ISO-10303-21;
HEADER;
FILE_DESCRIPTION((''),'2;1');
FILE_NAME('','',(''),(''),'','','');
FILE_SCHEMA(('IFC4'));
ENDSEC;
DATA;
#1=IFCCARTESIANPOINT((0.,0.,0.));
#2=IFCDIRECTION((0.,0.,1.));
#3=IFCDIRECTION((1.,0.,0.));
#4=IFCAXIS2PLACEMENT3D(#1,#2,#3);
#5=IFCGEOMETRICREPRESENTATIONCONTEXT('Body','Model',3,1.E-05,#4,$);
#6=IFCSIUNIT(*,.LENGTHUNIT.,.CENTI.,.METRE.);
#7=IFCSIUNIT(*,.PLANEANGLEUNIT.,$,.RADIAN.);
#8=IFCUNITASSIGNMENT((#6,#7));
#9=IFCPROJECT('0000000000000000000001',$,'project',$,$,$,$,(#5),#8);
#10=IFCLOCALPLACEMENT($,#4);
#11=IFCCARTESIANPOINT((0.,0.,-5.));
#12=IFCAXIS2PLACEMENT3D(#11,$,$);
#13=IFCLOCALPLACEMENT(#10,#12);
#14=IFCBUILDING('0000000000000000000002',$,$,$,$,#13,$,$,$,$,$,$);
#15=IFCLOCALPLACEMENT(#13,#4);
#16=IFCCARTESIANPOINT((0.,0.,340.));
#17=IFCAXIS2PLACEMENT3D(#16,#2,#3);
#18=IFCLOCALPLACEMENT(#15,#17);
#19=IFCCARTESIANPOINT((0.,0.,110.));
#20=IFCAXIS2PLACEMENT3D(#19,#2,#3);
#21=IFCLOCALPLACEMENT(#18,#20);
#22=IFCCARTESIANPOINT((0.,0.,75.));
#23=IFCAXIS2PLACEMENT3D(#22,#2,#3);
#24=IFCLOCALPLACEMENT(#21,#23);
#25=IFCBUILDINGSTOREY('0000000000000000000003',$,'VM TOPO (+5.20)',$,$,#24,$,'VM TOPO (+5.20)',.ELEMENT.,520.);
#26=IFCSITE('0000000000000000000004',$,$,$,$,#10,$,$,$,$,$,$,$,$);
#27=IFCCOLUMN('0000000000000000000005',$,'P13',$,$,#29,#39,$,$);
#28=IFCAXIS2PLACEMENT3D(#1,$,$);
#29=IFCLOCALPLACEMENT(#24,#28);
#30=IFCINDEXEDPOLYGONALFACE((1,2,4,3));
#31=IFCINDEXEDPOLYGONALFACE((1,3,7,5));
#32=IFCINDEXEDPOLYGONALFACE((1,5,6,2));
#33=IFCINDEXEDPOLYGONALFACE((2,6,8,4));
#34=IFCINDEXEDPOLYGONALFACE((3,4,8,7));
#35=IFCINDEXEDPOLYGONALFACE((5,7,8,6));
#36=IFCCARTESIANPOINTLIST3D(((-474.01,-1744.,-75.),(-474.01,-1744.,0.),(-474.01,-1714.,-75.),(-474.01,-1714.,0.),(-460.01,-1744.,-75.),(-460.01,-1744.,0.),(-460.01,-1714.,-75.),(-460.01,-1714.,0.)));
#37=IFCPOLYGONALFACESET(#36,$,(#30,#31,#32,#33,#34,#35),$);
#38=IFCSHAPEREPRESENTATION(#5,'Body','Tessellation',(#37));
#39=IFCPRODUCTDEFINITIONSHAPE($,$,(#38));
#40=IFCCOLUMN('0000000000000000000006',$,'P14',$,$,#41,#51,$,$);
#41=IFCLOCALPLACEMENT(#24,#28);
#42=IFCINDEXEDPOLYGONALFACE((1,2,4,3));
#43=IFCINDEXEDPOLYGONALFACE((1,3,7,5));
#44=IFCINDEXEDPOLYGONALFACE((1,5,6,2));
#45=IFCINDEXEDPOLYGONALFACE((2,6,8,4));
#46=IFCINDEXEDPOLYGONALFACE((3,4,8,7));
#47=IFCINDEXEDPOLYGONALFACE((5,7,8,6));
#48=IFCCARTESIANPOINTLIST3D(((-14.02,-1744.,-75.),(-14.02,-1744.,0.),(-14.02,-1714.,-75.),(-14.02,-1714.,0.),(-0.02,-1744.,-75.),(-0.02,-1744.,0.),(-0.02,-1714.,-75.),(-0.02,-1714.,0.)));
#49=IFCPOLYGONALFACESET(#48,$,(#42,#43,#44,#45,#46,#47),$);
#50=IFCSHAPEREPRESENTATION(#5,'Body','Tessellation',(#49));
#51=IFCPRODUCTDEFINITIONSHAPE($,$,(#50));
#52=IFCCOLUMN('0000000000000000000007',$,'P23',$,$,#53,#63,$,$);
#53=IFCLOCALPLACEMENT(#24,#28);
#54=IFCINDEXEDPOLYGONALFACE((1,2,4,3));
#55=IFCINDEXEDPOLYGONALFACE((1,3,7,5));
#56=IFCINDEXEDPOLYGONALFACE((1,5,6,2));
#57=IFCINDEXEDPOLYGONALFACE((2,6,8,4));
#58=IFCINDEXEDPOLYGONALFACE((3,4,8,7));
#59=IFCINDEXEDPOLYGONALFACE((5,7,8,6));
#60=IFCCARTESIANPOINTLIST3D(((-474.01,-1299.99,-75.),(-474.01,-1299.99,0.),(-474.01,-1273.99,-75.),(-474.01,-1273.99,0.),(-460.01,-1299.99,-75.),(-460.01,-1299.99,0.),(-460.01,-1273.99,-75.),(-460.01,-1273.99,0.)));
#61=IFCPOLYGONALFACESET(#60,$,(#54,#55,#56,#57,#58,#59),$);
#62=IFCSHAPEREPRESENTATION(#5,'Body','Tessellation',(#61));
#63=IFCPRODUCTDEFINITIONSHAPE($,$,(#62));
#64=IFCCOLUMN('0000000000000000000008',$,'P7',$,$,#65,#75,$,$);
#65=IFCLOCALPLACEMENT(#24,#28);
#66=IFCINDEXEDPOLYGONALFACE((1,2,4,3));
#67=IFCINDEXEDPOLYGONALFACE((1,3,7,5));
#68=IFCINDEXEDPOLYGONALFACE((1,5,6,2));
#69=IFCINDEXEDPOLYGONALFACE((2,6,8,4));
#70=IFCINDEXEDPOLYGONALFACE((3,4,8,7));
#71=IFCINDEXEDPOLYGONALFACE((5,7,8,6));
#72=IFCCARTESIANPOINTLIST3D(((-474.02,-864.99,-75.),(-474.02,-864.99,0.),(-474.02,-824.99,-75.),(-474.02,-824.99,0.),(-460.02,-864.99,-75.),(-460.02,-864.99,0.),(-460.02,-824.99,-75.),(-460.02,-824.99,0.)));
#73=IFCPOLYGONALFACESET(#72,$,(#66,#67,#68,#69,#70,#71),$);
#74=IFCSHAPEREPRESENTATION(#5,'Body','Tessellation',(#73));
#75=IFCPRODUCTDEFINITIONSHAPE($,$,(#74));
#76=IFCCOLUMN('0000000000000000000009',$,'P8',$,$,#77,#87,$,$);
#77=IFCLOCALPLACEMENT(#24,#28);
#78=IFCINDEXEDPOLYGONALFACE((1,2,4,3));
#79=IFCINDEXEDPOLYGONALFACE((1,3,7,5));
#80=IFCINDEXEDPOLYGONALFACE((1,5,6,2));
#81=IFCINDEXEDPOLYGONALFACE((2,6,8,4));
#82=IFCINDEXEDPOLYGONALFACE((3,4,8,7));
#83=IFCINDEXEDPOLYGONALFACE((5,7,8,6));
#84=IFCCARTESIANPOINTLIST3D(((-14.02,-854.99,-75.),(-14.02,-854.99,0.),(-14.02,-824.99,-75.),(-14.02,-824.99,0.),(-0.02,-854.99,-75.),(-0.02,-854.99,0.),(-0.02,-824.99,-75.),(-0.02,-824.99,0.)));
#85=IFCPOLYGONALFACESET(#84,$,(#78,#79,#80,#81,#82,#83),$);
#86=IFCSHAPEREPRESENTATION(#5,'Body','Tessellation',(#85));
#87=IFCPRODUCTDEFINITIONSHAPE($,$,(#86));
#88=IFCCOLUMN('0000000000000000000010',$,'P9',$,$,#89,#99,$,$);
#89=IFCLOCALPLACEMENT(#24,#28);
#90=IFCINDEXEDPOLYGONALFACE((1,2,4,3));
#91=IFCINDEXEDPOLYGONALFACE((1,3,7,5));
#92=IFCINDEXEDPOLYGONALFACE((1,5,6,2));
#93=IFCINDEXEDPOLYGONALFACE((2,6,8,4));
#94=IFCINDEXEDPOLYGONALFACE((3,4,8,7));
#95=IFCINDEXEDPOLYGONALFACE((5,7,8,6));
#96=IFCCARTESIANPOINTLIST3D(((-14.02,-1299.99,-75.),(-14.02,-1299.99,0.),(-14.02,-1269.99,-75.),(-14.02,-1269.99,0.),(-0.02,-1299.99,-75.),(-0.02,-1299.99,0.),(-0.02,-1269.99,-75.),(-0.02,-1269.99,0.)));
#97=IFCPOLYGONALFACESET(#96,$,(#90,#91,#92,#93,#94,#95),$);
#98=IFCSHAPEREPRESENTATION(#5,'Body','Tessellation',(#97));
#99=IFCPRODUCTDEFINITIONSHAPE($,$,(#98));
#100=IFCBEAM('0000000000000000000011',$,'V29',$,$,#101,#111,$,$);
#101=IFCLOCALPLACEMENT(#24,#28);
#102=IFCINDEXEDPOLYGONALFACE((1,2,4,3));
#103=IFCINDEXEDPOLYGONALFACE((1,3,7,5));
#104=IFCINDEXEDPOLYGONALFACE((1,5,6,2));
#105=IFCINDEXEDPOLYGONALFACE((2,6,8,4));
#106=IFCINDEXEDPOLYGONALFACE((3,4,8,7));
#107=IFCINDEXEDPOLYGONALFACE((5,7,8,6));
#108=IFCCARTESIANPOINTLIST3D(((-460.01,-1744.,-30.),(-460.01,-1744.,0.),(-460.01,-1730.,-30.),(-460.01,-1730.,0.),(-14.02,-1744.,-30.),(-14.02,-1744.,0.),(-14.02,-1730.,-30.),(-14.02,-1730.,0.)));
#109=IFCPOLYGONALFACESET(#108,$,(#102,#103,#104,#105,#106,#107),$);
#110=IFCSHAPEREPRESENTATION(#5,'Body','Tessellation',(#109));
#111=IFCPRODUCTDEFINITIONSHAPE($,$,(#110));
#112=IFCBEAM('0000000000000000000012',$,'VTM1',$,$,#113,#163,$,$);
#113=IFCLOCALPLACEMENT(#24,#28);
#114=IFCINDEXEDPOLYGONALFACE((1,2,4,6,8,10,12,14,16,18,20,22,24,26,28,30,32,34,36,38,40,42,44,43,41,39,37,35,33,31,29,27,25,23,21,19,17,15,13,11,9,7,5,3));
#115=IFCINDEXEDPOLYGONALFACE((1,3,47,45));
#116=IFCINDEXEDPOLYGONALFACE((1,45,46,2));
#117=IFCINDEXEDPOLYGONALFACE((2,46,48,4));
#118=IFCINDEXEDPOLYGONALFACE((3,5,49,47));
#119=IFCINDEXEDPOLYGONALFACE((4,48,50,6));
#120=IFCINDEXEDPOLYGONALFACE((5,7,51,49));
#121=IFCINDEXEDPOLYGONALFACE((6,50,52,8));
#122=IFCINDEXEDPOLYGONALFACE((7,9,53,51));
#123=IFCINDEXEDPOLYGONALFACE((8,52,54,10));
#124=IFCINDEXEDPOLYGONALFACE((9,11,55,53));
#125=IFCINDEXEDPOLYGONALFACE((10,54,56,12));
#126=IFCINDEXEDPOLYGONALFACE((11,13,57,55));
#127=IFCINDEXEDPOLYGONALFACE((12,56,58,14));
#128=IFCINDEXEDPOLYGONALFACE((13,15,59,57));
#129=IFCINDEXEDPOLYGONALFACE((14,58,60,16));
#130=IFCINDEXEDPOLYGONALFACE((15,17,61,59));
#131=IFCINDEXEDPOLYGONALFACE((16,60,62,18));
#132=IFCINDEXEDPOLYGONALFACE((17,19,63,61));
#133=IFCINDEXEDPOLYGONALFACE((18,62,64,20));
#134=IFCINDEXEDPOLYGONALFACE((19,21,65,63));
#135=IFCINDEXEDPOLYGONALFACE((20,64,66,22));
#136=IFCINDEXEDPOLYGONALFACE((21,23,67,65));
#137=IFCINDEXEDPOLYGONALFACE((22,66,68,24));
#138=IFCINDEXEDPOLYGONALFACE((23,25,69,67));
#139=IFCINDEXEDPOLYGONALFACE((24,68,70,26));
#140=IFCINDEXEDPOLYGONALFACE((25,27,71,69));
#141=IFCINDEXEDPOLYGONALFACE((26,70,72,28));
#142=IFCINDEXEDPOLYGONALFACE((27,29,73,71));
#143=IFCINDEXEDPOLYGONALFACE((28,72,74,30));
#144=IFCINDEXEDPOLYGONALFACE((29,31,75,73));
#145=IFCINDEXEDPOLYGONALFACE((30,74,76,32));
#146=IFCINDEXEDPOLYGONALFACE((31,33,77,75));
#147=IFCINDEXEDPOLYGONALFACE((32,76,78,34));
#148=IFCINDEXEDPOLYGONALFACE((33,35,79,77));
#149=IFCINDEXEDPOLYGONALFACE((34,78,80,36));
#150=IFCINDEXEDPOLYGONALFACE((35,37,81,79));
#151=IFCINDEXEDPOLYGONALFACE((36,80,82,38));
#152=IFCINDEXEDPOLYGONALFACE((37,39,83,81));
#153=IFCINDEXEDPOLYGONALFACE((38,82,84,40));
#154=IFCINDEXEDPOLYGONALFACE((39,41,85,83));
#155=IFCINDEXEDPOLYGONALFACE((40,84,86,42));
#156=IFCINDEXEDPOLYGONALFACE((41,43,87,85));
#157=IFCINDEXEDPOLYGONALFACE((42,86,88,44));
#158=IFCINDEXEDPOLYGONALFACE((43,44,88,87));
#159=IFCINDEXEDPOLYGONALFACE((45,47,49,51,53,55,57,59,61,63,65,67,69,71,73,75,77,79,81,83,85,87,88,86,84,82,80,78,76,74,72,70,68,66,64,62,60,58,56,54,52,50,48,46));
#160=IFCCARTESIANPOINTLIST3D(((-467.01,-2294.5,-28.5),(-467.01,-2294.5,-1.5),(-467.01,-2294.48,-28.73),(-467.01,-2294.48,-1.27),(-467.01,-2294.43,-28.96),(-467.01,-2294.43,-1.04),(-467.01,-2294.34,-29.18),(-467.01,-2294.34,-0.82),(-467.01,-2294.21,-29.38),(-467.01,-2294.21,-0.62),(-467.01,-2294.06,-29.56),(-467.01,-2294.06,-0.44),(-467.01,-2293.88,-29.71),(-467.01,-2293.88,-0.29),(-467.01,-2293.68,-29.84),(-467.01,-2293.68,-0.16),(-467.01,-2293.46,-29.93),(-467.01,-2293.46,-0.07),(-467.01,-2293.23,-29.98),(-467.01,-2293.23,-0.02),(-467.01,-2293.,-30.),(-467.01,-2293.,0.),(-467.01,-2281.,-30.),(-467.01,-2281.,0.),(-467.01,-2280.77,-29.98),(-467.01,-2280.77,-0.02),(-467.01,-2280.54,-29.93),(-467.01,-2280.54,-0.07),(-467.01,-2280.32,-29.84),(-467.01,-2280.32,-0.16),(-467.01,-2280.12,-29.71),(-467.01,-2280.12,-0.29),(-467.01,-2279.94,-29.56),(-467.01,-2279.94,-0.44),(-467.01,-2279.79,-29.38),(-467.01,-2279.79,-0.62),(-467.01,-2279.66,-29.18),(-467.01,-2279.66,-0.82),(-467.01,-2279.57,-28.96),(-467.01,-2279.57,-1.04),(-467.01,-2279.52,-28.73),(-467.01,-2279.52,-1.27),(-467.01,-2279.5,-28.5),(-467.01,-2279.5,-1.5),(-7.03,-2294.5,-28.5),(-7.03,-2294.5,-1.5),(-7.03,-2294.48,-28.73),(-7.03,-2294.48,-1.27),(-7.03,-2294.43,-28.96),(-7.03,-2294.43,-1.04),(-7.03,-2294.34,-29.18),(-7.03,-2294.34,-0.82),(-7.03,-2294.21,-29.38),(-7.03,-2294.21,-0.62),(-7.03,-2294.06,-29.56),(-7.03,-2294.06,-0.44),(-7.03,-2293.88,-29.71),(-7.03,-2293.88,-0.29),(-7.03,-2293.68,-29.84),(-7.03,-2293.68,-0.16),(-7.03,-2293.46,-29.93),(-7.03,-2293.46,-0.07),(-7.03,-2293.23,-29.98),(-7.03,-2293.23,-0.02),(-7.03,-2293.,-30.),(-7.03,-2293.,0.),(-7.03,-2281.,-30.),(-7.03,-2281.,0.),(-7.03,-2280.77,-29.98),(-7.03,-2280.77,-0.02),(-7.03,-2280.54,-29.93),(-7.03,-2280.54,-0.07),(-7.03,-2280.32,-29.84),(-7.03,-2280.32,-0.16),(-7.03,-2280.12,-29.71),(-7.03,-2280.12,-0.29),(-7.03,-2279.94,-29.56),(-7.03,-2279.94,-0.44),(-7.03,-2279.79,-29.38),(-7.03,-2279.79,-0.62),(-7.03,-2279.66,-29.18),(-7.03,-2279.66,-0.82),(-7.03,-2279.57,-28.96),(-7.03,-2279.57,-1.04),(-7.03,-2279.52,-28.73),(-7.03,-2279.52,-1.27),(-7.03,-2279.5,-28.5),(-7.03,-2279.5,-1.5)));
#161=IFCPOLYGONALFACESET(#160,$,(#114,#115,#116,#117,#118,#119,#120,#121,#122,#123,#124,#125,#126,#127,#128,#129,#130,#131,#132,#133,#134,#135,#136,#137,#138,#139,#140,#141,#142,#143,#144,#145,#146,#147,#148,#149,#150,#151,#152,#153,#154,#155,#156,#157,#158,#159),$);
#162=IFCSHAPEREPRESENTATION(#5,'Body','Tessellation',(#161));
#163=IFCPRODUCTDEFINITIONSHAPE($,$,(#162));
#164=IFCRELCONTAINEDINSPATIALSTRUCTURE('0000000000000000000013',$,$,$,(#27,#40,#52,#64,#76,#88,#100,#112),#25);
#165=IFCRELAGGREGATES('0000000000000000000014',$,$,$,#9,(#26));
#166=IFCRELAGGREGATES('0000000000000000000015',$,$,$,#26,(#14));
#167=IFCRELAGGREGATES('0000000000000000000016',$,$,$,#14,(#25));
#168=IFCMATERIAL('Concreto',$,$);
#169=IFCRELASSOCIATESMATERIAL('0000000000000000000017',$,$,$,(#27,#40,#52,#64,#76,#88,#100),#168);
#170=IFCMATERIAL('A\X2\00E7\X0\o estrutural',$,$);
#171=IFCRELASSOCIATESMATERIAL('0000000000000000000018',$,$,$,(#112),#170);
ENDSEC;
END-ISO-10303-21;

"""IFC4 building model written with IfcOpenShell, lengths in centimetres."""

from ifc_helpers import new_model, si_unit, frame, origin_with_axes, origin_2d_with_axis, place, context, project, spatial, polyline, rectangle, outline, extrude, material, element, save


model = new_model("IFC4")

# Units and contexts
model_context = context("Model", 3, precision=1e-05, world=origin_with_axes(), identifier="Body")
ifc_project = project(units=[si_unit("LENGTHUNIT", "METRE", prefix="CENTI"), si_unit("PLANEANGLEUNIT", "RADIAN")], contexts=[model_context])

# Site, building, storey
site_placement = place(None, origin_with_axes())
site = spatial("IfcSite", under=ifc_project, at=site_placement)
building_placement = place(site_placement, frame((0.0, 0.0, -5.0)))
building = spatial("IfcBuilding", under=site, at=building_placement)
placement_1 = place(building_placement, origin_with_axes())
placement_2 = place(placement_1, frame((0.0, 0.0, 340.0), z_axis=(0.0, 0.0, 1.0), x_axis=(1.0, 0.0, 0.0)))
placement_3 = place(placement_2, frame((0.0, 0.0, 110.0), z_axis=(0.0, 0.0, 1.0), x_axis=(1.0, 0.0, 0.0)))
storey_placement = place(placement_3, frame((0.0, 0.0, 75.0), z_axis=(0.0, 0.0, 1.0), x_axis=(1.0, 0.0, 0.0)))
storey = spatial("IfcBuildingStorey", under=building, at=storey_placement, Name="VM TOPO (+5.20)", LongName="VM TOPO (+5.20)", CompositionType="ELEMENT", Elevation=520.0)

# Columns
ifc_material_1 = material(Name="Concreto")
for number, where, z_axis, x_axis, name in (
    (1, (-467.01, -1729.0, 0.0), (0.0, 0.0, 1.0), (1.0, 0.0, 0.0), "P13"),
    (2, (-7.02, -1729.0, 0.0), (0.0, 0.0, 1.0), (1.0, 0.0, 0.0), "P14"),
):
    element("IfcColumn", number, at=place(storey_placement, frame(where, z_axis=z_axis, x_axis=x_axis)), inside=storey, material=ifc_material_1, Name=name, context=model_context, shape_type="SolidModel", body=[
        extrude(rectangle(XDim=14.0, YDim=30.0, at=origin_2d_with_axis()), origin_with_axes(), (0.0, 0.0, -1.0), 75.0),
    ])
column_1_placement = place(storey_placement, frame((-467.01, -1286.99, 0.0), z_axis=(0.0, 0.0, 1.0), x_axis=(1.0, 0.0, 0.0)))
element("IfcColumn", 3, at=column_1_placement, inside=storey, material=ifc_material_1, Name="P23", context=model_context, shape_type="SolidModel", body=[
    extrude(rectangle(XDim=14.0, YDim=26.0, at=origin_2d_with_axis()), origin_with_axes(), (0.0, 0.0, -1.0), 75.0),
])
column_2_placement = place(storey_placement, frame((-467.02, -844.99, 0.0), z_axis=(0.0, 0.0, 1.0), x_axis=(1.0, 0.0, 0.0)))
element("IfcColumn", 4, at=column_2_placement, inside=storey, material=ifc_material_1, Name="P7", context=model_context, shape_type="SolidModel", body=[
    extrude(rectangle(XDim=14.0, YDim=40.0, at=origin_2d_with_axis()), origin_with_axes(), (0.0, 0.0, -1.0), 75.0),
])
for number, where, z_axis, x_axis, name in (
    (5, (-7.02, -839.99, 0.0), (0.0, 0.0, 1.0), (1.0, 0.0, 0.0), "P8"),
    (6, (-7.02, -1284.99, 0.0), (0.0, 0.0, 1.0), (1.0, 0.0, 0.0), "P9"),
):
    element("IfcColumn", number, at=place(storey_placement, frame(where, z_axis=z_axis, x_axis=x_axis)), inside=storey, material=ifc_material_1, Name=name, context=model_context, shape_type="SolidModel", body=[
        extrude(rectangle(XDim=14.0, YDim=30.0, at=origin_2d_with_axis()), origin_with_axes(), (0.0, 0.0, -1.0), 75.0),
    ])

# Beams
beam_1_placement = place(storey_placement, frame((-237.01, -1737.0, 0.0), z_axis=(0.0, 0.0, 1.0), x_axis=(1.0, 0.0, 0.0)))
element("IfcBeam", 7, at=beam_1_placement, inside=storey, material=ifc_material_1, Name="V29", context=model_context, shape_type="SolidModel", body=[
    extrude(rectangle(XDim=14.0, YDim=30.0, at=origin_2d_with_axis()), frame((-223.0, 0.0, -15.0), z_axis=(1.0, 0.0, 0.0), x_axis=(0.0, -1.0, 0.0)), (0.0, 0.0, 1.0), 445.99),
])
ifc_material_2 = material(Name="Aço estrutural")
beam_2_placement = place(storey_placement, frame((-237.02, -2287.0, 0.0), z_axis=(0.0, 0.0, 1.0), x_axis=(1.0, 0.0, 0.0)))
element("IfcBeam", 8, at=beam_2_placement, inside=storey, material=ifc_material_2, Name="VTM1", context=model_context, shape_type="SolidModel", body=[
    extrude(outline(polyline([(6.0, -15.0), (6.23, -14.98), (6.46, -14.93), (6.68, -14.84), (6.88, -14.71), (7.06, -14.56), (7.21, -14.38), (7.34, -14.18), (7.43, -13.96), (7.48, -13.73), (7.5, -13.5), (7.5, 13.5), (7.48, 13.73), (7.43, 13.96), (7.34, 14.18), (7.21, 14.38), (7.06, 14.56), (6.88, 14.71), (6.68, 14.84), (6.46, 14.93), (6.23, 14.98), (6.0, 15.0), (-6.0, 15.0), (-6.23, 14.98), (-6.46, 14.93), (-6.68, 14.84), (-6.88, 14.71), (-7.06, 14.56), (-7.21, 14.38), (-7.34, 14.18), (-7.43, 13.96), (-7.48, 13.73), (-7.5, 13.5), (-7.5, -13.5), (-7.48, -13.73), (-7.43, -13.96), (-7.34, -14.18), (-7.21, -14.38), (-7.06, -14.56), (-6.88, -14.71), (-6.68, -14.84), (-6.46, -14.93), (-6.23, -14.98), (-6.0, -15.0), (6.0, -15.0)])), frame((-229.99, 0.0, -15.0), z_axis=(1.0, 0.0, 0.0), x_axis=(0.0, -1.0, 0.0)), (0.0, 0.0, 1.0), 459.98),
])

save(model, "model.ifc")
